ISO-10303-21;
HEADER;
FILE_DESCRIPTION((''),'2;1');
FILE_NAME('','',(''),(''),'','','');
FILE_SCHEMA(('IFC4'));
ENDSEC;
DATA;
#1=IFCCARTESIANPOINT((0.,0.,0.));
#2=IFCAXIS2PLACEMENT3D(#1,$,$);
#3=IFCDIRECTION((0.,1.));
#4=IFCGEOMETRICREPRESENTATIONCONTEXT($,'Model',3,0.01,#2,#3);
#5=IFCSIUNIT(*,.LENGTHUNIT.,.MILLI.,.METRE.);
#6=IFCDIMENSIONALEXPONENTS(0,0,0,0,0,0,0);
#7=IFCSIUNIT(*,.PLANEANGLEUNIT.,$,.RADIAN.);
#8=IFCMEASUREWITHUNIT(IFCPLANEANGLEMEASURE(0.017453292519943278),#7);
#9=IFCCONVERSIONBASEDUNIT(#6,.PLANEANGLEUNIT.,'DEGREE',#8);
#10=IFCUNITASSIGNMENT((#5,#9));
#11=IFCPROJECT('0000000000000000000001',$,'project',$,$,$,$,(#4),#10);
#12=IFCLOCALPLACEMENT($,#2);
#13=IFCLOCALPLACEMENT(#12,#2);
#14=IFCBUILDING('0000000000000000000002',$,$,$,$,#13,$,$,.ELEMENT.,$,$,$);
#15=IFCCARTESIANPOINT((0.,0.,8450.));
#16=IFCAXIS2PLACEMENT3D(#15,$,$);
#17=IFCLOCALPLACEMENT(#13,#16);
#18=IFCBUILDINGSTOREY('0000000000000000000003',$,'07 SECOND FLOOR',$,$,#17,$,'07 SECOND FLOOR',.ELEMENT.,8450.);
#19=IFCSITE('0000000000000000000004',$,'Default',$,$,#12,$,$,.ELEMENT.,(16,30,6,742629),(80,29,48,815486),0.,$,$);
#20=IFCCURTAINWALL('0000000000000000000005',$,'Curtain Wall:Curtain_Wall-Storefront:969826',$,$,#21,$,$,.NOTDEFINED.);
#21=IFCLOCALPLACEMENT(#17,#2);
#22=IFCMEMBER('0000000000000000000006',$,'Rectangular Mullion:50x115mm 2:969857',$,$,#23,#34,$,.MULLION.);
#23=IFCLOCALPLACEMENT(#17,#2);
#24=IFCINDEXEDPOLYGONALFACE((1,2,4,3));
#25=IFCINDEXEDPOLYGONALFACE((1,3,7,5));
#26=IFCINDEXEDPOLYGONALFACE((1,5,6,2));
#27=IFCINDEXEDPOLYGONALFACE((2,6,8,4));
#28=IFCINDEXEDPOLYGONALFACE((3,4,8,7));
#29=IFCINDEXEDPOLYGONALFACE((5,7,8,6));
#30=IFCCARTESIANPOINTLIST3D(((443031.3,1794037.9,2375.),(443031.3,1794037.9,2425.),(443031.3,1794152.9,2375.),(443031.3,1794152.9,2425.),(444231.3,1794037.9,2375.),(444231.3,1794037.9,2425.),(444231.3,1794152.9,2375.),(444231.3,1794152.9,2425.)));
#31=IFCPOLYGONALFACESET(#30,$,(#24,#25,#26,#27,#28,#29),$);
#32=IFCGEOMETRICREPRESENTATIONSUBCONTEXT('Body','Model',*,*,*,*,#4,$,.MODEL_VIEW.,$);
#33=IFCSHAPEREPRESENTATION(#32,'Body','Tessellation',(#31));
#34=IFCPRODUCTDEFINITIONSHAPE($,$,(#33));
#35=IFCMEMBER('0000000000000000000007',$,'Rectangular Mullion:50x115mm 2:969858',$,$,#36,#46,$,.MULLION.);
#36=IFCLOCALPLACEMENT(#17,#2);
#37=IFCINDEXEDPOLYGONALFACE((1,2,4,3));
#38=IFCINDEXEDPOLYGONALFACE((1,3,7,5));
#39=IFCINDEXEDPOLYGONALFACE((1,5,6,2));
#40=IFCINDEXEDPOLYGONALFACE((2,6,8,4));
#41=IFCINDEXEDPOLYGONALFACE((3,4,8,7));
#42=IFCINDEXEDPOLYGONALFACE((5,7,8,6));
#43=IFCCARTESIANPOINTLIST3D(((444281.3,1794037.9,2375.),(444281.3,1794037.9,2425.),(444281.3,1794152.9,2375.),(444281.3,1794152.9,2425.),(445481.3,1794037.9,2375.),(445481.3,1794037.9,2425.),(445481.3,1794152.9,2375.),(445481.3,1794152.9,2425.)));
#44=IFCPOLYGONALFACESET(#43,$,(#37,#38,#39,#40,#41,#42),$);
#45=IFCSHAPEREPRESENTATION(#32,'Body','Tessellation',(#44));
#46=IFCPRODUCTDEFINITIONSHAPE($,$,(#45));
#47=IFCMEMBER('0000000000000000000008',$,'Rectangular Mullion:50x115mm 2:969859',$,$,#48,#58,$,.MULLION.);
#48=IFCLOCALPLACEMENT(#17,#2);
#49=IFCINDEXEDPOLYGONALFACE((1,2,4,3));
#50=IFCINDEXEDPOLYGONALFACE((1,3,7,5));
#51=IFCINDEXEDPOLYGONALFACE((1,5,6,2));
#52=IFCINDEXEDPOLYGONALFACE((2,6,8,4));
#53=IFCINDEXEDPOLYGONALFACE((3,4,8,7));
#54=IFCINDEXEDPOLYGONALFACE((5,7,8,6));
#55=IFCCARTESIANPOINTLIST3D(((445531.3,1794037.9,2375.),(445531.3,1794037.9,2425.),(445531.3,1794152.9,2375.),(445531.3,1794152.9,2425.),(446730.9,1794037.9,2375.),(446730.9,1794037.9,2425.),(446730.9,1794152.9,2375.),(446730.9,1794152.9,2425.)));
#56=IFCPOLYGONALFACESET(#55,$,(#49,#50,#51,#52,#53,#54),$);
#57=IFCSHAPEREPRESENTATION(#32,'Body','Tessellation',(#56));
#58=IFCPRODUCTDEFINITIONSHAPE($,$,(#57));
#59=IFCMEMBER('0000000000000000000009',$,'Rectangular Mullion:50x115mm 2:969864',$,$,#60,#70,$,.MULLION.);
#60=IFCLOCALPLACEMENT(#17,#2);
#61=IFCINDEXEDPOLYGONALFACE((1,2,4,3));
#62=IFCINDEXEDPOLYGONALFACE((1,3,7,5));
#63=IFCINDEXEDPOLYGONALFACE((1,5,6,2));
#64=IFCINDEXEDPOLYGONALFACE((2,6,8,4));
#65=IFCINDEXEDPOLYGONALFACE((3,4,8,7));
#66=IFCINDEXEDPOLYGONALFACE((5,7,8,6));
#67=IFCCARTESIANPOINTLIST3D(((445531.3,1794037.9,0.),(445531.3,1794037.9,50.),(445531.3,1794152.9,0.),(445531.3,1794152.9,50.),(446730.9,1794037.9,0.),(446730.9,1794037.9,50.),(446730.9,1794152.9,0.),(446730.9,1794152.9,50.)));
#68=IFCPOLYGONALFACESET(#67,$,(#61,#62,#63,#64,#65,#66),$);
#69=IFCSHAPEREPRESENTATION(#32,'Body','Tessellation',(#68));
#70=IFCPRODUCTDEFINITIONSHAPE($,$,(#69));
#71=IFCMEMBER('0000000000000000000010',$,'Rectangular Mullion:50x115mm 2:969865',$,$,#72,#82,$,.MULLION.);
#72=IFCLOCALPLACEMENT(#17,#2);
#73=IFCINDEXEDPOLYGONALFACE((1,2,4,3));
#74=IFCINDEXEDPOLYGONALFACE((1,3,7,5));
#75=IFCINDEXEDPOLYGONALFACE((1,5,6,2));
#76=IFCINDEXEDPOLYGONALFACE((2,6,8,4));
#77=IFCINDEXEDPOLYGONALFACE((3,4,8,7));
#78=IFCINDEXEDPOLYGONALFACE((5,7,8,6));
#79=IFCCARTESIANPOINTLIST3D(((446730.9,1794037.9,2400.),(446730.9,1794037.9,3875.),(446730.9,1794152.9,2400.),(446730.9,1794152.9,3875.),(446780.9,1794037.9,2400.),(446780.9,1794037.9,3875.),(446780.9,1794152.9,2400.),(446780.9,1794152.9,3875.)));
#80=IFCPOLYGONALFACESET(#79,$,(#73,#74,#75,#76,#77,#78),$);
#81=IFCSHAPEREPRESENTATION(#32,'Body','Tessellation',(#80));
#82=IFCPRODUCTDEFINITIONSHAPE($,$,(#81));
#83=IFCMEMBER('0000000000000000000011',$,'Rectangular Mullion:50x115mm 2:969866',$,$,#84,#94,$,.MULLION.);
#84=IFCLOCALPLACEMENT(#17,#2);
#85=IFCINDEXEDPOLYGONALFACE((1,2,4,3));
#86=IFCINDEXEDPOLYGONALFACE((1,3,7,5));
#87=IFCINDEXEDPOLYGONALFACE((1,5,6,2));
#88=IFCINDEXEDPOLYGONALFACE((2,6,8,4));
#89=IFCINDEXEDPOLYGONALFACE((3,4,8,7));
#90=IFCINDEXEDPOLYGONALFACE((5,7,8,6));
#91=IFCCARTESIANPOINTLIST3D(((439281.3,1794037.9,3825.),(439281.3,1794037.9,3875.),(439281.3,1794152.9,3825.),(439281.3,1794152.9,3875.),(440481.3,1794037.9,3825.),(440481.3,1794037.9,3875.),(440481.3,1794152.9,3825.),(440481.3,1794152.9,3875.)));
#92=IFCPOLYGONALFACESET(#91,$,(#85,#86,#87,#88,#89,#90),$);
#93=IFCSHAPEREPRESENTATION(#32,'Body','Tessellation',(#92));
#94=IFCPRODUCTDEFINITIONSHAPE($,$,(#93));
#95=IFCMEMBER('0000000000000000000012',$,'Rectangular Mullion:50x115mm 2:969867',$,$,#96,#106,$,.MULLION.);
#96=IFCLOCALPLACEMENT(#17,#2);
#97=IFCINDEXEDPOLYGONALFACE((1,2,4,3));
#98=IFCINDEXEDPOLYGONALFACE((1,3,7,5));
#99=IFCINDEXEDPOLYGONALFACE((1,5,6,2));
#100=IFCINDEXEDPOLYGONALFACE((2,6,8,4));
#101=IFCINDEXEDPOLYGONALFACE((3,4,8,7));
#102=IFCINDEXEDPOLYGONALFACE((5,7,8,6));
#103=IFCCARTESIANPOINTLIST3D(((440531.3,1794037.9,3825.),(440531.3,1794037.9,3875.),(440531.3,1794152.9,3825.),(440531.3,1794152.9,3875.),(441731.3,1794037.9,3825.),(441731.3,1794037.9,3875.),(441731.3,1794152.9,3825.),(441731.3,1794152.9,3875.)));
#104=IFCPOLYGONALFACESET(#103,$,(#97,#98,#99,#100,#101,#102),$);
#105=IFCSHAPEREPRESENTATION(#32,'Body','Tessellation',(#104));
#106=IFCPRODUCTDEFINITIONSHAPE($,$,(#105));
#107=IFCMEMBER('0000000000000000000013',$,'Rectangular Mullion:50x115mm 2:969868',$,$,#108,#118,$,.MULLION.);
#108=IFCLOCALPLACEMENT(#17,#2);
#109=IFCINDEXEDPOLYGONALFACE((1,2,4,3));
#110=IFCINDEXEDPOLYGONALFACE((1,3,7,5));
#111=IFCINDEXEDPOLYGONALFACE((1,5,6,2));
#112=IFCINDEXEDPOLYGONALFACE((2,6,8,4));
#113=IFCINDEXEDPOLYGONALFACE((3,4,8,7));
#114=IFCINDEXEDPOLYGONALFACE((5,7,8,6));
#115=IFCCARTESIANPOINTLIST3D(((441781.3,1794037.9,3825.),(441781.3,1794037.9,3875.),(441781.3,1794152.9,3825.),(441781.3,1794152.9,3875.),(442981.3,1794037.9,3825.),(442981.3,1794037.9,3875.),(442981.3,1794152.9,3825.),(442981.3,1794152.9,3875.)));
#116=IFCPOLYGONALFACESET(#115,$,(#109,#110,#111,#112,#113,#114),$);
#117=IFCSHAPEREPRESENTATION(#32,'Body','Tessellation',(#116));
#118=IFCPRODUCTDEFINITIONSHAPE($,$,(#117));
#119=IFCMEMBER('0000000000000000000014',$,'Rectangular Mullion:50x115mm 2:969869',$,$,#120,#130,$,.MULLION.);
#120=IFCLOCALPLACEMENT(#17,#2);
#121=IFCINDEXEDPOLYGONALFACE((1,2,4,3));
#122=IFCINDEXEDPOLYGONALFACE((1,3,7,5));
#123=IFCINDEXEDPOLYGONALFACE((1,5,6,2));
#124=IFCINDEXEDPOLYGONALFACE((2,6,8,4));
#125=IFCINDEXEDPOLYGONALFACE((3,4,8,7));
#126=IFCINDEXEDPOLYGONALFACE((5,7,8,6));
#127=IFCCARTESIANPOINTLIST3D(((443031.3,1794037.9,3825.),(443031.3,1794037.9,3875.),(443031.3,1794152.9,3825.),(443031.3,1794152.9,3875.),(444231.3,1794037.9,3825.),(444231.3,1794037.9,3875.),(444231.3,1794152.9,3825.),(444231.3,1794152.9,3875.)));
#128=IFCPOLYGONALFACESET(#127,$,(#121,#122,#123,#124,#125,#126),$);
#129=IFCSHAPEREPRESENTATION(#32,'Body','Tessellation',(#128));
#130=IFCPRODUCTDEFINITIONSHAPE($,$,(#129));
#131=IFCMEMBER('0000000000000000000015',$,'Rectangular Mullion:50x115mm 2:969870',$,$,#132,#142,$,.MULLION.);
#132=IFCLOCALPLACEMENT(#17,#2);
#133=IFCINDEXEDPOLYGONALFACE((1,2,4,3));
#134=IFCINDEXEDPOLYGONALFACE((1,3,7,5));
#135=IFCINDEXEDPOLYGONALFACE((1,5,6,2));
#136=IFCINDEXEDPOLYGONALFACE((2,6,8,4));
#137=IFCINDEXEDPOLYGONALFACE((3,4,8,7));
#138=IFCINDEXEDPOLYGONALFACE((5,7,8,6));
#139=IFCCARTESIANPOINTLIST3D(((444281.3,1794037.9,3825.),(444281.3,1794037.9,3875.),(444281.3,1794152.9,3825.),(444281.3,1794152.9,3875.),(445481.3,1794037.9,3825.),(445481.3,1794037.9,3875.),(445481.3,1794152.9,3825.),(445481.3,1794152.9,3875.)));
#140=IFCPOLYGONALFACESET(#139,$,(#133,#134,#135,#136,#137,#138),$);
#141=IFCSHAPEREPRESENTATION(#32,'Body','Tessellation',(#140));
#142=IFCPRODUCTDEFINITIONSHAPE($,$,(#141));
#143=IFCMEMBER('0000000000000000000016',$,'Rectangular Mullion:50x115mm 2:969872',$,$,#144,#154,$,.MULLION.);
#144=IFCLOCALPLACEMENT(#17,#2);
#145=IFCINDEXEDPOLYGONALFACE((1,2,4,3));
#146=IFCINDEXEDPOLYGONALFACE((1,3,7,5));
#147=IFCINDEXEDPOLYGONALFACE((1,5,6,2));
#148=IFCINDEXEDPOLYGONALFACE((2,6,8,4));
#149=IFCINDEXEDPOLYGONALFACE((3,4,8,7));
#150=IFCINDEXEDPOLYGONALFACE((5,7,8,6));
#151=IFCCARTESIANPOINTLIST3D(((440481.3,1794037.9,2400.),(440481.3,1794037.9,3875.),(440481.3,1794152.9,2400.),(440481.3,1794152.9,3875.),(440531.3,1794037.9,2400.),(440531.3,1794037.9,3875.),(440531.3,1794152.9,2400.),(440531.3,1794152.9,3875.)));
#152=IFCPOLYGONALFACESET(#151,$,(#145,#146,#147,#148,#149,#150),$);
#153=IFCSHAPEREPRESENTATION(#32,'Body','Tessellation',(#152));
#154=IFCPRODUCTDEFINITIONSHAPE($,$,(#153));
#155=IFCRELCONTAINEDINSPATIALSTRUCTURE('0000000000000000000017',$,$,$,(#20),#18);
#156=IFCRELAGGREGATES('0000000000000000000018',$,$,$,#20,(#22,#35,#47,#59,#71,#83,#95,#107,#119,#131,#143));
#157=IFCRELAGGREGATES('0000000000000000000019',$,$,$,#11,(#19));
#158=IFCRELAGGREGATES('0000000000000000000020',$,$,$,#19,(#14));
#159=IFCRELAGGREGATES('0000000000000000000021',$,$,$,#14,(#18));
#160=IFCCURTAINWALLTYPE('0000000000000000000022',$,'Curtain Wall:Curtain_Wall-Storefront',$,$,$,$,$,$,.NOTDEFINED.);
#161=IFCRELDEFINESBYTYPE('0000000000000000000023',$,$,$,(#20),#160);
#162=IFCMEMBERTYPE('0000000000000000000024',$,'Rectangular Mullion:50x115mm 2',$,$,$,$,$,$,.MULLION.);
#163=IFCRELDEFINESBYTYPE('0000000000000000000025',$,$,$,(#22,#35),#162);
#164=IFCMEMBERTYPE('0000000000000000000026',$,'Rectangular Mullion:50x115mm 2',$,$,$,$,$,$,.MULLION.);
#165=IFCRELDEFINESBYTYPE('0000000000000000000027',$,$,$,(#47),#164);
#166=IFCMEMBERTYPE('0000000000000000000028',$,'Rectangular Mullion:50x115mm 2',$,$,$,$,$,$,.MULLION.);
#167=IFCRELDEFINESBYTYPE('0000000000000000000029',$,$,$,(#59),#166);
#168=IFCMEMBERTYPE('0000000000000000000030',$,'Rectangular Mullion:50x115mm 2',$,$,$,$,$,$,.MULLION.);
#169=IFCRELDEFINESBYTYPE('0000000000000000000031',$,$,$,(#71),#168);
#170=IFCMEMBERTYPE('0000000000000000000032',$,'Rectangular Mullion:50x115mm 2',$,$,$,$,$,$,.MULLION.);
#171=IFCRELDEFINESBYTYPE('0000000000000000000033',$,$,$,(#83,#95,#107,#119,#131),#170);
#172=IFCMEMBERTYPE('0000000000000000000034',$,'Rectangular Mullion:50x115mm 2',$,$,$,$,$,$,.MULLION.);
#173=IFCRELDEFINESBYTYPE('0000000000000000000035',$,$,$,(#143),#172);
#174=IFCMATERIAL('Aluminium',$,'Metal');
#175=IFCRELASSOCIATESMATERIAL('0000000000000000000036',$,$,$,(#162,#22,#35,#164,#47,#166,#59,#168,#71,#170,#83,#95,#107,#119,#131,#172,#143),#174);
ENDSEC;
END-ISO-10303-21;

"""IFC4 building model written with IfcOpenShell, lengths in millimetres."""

from ifc_helpers import new_model, entity, si_unit, converted_unit, direction, frame, origin, place, context, subcontext, project, spatial, indexed_curve, outline, extrude, source, transform, mapped, material, type_object, type_shapes, element, aggregate, save


model = new_model("IFC4")

# Units and contexts
model_context = context("Model", 3, precision=0.01, world=origin(), true_north=direction((0.0, 1.0)))
body_context = subcontext(model_context, "Body", "Model", "MODEL_VIEW")
ifc_project = project(units=[si_unit("LENGTHUNIT", "METRE", prefix="MILLI"), converted_unit("PLANEANGLEUNIT", "DEGREE", entity("IfcPlaneAngleMeasure", 0.017453292519943278), si_unit("PLANEANGLEUNIT", "RADIAN"), dimensions=[0, 0, 0, 0, 0, 0, 0])], contexts=[model_context])

# Site, building, storey
site_placement = place(None, origin())
site = spatial("IfcSite", under=ifc_project, at=site_placement, Name="Default", CompositionType="ELEMENT", RefLatitude=(16, 30, 6, 742629), RefLongitude=(80, 29, 48, 815486), RefElevation=0.0)
building_placement = place(site_placement, origin())
building = spatial("IfcBuilding", under=site, at=building_placement, CompositionType="ELEMENT")
storey_placement = place(building_placement, frame((0.0, 0.0, 8450.0)))
storey = spatial("IfcBuildingStorey", under=building, at=storey_placement, Name="07 SECOND FLOOR", LongName="07 SECOND FLOOR", CompositionType="ELEMENT", Elevation=8450.0)

# Curtain wall, members
curtain_wall_type = type_object("IfcCurtainWallType", Name="Curtain Wall:Curtain_Wall-Storefront", PredefinedType="NOTDEFINED")
curtain_wall_placement = place(storey_placement, frame((0.0, 0.0, -8450.0)))
curtain_wall = element("IfcCurtainWall", 1, at=curtain_wall_placement, inside=storey, type_object=curtain_wall_type, Name="Curtain Wall:Curtain_Wall-Storefront:969826", PredefinedType="NOTDEFINED")
ifc_material = material(Name="Aluminium", Category="Metal")
member_type_1 = type_object("IfcMemberType", Name="Rectangular Mullion:50x115mm 2", PredefinedType="MULLION", material=ifc_material)
shared_shape_1 = source(origin(), body_context, "Body", "SweptSolid", [
    extrude(outline(indexed_curve([(-25.0, -57.5), (25.0, -57.5), (25.0, 57.5), (-25.0, 57.5), (-25.0, -57.5)], self_intersect=False)), frame((0.0, 0.0, -1200.0), z_axis=(0.0, 0.0, 1.0), x_axis=(-1.0, 0.0, 0.0)), (0.0, 0.0, 1.0), 1200.0),
])
type_shapes(member_type_1, [shared_shape_1])
member_1_placement = place(curtain_wall_placement, frame((444231.3, 1794095.4, 10850.0), z_axis=(1.0, 0.0, 0.0), x_axis=(0.0, 0.0, 1.0)))
member_1 = element("IfcMember", 2, at=member_1_placement, type_object=member_type_1, material=ifc_material, Name="Rectangular Mullion:50x115mm 2:969857", PredefinedType="MULLION", context=body_context, shape_type="MappedRepresentation", body=[
    mapped(shared_shape_1, transform((0.0, 0.0, 0.0), scale=1.0)),
])
member_2_placement = place(curtain_wall_placement, frame((445481.3, 1794095.4, 10850.0), z_axis=(1.0, 0.0, 0.0), x_axis=(0.0, 0.0, 1.0)))
member_2 = element("IfcMember", 3, at=member_2_placement, type_object=member_type_1, material=ifc_material, Name="Rectangular Mullion:50x115mm 2:969858", PredefinedType="MULLION", context=body_context, shape_type="MappedRepresentation", body=[
    mapped(shared_shape_1, transform((0.0, 0.0, 0.0), scale=1.0)),
])
member_type_2 = type_object("IfcMemberType", Name="Rectangular Mullion:50x115mm 2", PredefinedType="MULLION", material=ifc_material)
shared_shape_2 = source(origin(), body_context, "Body", "SweptSolid", [
    extrude(outline(indexed_curve([(-25.0, -57.5), (25.0, -57.5), (25.0, 57.5), (-25.0, 57.5), (-25.0, -57.5)], self_intersect=False)), frame((0.0, 0.0, -1199.6), z_axis=(0.0, 0.0, 1.0), x_axis=(-1.0, 0.0, 0.0)), (0.0, 0.0, 1.0), 1199.6),
])
type_shapes(member_type_2, [shared_shape_2])
member_3_placement = place(curtain_wall_placement, frame((446730.9, 1794095.4, 10850.0), z_axis=(1.0, 0.0, 0.0), x_axis=(0.0, 0.0, 1.0)))
member_3 = element("IfcMember", 4, at=member_3_placement, type_object=member_type_2, material=ifc_material, Name="Rectangular Mullion:50x115mm 2:969859", PredefinedType="MULLION", context=body_context, shape_type="MappedRepresentation", body=[
    mapped(shared_shape_2, transform((0.0, 0.0, 0.0), scale=1.0)),
])
member_type_3 = type_object("IfcMemberType", Name="Rectangular Mullion:50x115mm 2", PredefinedType="MULLION", material=ifc_material)
shared_shape_3 = source(origin(), body_context, "Body", "SweptSolid", [
    extrude(outline(indexed_curve([(-25.0, -57.5), (25.0, -57.5), (25.0, 57.5), (-25.0, 57.5), (-25.0, -57.5)], self_intersect=False)), frame((-25.0, 0.0, -1199.6), z_axis=(0.0, 0.0, 1.0), x_axis=(-1.0, 0.0, 0.0)), (0.0, 0.0, 1.0), 1199.6),
])
type_shapes(member_type_3, [shared_shape_3])
member_4_placement = place(curtain_wall_placement, frame((445531.3, 1794095.4, 8450.0), z_axis=(-1.0, 0.0, 0.0), x_axis=(0.0, 0.0, -1.0)))
member_4 = element("IfcMember", 5, at=member_4_placement, type_object=member_type_3, material=ifc_material, Name="Rectangular Mullion:50x115mm 2:969864", PredefinedType="MULLION", context=body_context, shape_type="MappedRepresentation", body=[
    mapped(shared_shape_3, transform((0.0, 0.0, 0.0), scale=1.0)),
])
member_type_4 = type_object("IfcMemberType", Name="Rectangular Mullion:50x115mm 2", PredefinedType="MULLION", material=ifc_material)
shared_shape_4 = source(origin(), body_context, "Body", "SweptSolid", [
    extrude(outline(indexed_curve([(-25.0, -57.5), (25.0, -57.5), (25.0, 57.5), (-25.0, 57.5), (-25.0, -57.5)], self_intersect=False)), frame((-25.0, 0.0, -1475.0), z_axis=(0.0, 0.0, 1.0), x_axis=(-1.0, 0.0, 0.0)), (0.0, 0.0, 1.0), 1475.0),
])
type_shapes(member_type_4, [shared_shape_4])
member_5_placement = place(curtain_wall_placement, frame((446780.9, 1794095.4, 10850.0), z_axis=(0.0, 0.0, -1.0), x_axis=(1.0, 0.0, 0.0)))
member_5 = element("IfcMember", 6, at=member_5_placement, type_object=member_type_4, material=ifc_material, Name="Rectangular Mullion:50x115mm 2:969865", PredefinedType="MULLION", context=body_context, shape_type="MappedRepresentation", body=[
    mapped(shared_shape_4, transform((0.0, 0.0, 0.0), scale=1.0)),
])
member_type_5 = type_object("IfcMemberType", Name="Rectangular Mullion:50x115mm 2", PredefinedType="MULLION", material=ifc_material)
shared_shape_5 = source(origin(), body_context, "Body", "SweptSolid", [
    extrude(outline(indexed_curve([(-25.0, -57.5), (25.0, -57.5), (25.0, 57.5), (-25.0, 57.5), (-25.0, -57.5)], self_intersect=False)), frame((-25.0, 0.0, -1200.0), z_axis=(0.0, 0.0, 1.0), x_axis=(-1.0, 0.0, 0.0)), (0.0, 0.0, 1.0), 1200.0),
])
type_shapes(member_type_5, [shared_shape_5])
member_6_placement = place(curtain_wall_placement, frame((440481.3, 1794095.4, 12325.0), z_axis=(1.0, 0.0, 0.0), x_axis=(0.0, 0.0, 1.0)))
member_6 = element("IfcMember", 7, at=member_6_placement, type_object=member_type_5, material=ifc_material, Name="Rectangular Mullion:50x115mm 2:969866", PredefinedType="MULLION", context=body_context, shape_type="MappedRepresentation", body=[
    mapped(shared_shape_5, transform((0.0, 0.0, 0.0), scale=1.0)),
])
member_7_placement = place(curtain_wall_placement, frame((441731.3, 1794095.4, 12325.0), z_axis=(1.0, 0.0, 0.0), x_axis=(0.0, 0.0, 1.0)))
member_7 = element("IfcMember", 8, at=member_7_placement, type_object=member_type_5, material=ifc_material, Name="Rectangular Mullion:50x115mm 2:969867", PredefinedType="MULLION", context=body_context, shape_type="MappedRepresentation", body=[
    mapped(shared_shape_5, transform((0.0, 0.0, 0.0), scale=1.0)),
])
member_8_placement = place(curtain_wall_placement, frame((442981.3, 1794095.4, 12325.0), z_axis=(1.0, 0.0, 0.0), x_axis=(0.0, 0.0, 1.0)))
member_8 = element("IfcMember", 9, at=member_8_placement, type_object=member_type_5, material=ifc_material, Name="Rectangular Mullion:50x115mm 2:969868", PredefinedType="MULLION", context=body_context, shape_type="MappedRepresentation", body=[
    mapped(shared_shape_5, transform((0.0, 0.0, 0.0), scale=1.0)),
])
member_9_placement = place(curtain_wall_placement, frame((444231.3, 1794095.4, 12325.0), z_axis=(1.0, 0.0, 0.0), x_axis=(0.0, 0.0, 1.0)))
member_9 = element("IfcMember", 10, at=member_9_placement, type_object=member_type_5, material=ifc_material, Name="Rectangular Mullion:50x115mm 2:969869", PredefinedType="MULLION", context=body_context, shape_type="MappedRepresentation", body=[
    mapped(shared_shape_5, transform((0.0, 0.0, 0.0), scale=1.0)),
])
member_10_placement = place(curtain_wall_placement, frame((445481.3, 1794095.4, 12325.0), z_axis=(1.0, 0.0, 0.0), x_axis=(0.0, 0.0, 1.0)))
member_10 = element("IfcMember", 11, at=member_10_placement, type_object=member_type_5, material=ifc_material, Name="Rectangular Mullion:50x115mm 2:969870", PredefinedType="MULLION", context=body_context, shape_type="MappedRepresentation", body=[
    mapped(shared_shape_5, transform((0.0, 0.0, 0.0), scale=1.0)),
])
member_type_6 = type_object("IfcMemberType", Name="Rectangular Mullion:50x115mm 2", PredefinedType="MULLION", material=ifc_material)
shared_shape_6 = source(origin(), body_context, "Body", "SweptSolid", [
    extrude(outline(indexed_curve([(-25.0, -57.5), (25.0, -57.5), (25.0, 57.5), (-25.0, 57.5), (-25.0, -57.5)], self_intersect=False)), frame((0.0, 0.0, -1475.0), z_axis=(0.0, 0.0, 1.0), x_axis=(-1.0, 0.0, 0.0)), (0.0, 0.0, 1.0), 1475.0),
])
type_shapes(member_type_6, [shared_shape_6])
member_11_placement = place(curtain_wall_placement, frame((440506.3, 1794095.4, 10850.0), z_axis=(0.0, 0.0, -1.0), x_axis=(1.0, 0.0, 0.0)))
member_11 = element("IfcMember", 12, at=member_11_placement, type_object=member_type_6, material=ifc_material, Name="Rectangular Mullion:50x115mm 2:969872", PredefinedType="MULLION", context=body_context, shape_type="MappedRepresentation", body=[
    mapped(shared_shape_6, transform((0.0, 0.0, 0.0), scale=1.0)),
])
aggregate(curtain_wall, [member_1, member_2, member_3, member_4, member_5, member_6, member_7, member_8, member_9, member_10, member_11])

save(model, "model.ifc")
